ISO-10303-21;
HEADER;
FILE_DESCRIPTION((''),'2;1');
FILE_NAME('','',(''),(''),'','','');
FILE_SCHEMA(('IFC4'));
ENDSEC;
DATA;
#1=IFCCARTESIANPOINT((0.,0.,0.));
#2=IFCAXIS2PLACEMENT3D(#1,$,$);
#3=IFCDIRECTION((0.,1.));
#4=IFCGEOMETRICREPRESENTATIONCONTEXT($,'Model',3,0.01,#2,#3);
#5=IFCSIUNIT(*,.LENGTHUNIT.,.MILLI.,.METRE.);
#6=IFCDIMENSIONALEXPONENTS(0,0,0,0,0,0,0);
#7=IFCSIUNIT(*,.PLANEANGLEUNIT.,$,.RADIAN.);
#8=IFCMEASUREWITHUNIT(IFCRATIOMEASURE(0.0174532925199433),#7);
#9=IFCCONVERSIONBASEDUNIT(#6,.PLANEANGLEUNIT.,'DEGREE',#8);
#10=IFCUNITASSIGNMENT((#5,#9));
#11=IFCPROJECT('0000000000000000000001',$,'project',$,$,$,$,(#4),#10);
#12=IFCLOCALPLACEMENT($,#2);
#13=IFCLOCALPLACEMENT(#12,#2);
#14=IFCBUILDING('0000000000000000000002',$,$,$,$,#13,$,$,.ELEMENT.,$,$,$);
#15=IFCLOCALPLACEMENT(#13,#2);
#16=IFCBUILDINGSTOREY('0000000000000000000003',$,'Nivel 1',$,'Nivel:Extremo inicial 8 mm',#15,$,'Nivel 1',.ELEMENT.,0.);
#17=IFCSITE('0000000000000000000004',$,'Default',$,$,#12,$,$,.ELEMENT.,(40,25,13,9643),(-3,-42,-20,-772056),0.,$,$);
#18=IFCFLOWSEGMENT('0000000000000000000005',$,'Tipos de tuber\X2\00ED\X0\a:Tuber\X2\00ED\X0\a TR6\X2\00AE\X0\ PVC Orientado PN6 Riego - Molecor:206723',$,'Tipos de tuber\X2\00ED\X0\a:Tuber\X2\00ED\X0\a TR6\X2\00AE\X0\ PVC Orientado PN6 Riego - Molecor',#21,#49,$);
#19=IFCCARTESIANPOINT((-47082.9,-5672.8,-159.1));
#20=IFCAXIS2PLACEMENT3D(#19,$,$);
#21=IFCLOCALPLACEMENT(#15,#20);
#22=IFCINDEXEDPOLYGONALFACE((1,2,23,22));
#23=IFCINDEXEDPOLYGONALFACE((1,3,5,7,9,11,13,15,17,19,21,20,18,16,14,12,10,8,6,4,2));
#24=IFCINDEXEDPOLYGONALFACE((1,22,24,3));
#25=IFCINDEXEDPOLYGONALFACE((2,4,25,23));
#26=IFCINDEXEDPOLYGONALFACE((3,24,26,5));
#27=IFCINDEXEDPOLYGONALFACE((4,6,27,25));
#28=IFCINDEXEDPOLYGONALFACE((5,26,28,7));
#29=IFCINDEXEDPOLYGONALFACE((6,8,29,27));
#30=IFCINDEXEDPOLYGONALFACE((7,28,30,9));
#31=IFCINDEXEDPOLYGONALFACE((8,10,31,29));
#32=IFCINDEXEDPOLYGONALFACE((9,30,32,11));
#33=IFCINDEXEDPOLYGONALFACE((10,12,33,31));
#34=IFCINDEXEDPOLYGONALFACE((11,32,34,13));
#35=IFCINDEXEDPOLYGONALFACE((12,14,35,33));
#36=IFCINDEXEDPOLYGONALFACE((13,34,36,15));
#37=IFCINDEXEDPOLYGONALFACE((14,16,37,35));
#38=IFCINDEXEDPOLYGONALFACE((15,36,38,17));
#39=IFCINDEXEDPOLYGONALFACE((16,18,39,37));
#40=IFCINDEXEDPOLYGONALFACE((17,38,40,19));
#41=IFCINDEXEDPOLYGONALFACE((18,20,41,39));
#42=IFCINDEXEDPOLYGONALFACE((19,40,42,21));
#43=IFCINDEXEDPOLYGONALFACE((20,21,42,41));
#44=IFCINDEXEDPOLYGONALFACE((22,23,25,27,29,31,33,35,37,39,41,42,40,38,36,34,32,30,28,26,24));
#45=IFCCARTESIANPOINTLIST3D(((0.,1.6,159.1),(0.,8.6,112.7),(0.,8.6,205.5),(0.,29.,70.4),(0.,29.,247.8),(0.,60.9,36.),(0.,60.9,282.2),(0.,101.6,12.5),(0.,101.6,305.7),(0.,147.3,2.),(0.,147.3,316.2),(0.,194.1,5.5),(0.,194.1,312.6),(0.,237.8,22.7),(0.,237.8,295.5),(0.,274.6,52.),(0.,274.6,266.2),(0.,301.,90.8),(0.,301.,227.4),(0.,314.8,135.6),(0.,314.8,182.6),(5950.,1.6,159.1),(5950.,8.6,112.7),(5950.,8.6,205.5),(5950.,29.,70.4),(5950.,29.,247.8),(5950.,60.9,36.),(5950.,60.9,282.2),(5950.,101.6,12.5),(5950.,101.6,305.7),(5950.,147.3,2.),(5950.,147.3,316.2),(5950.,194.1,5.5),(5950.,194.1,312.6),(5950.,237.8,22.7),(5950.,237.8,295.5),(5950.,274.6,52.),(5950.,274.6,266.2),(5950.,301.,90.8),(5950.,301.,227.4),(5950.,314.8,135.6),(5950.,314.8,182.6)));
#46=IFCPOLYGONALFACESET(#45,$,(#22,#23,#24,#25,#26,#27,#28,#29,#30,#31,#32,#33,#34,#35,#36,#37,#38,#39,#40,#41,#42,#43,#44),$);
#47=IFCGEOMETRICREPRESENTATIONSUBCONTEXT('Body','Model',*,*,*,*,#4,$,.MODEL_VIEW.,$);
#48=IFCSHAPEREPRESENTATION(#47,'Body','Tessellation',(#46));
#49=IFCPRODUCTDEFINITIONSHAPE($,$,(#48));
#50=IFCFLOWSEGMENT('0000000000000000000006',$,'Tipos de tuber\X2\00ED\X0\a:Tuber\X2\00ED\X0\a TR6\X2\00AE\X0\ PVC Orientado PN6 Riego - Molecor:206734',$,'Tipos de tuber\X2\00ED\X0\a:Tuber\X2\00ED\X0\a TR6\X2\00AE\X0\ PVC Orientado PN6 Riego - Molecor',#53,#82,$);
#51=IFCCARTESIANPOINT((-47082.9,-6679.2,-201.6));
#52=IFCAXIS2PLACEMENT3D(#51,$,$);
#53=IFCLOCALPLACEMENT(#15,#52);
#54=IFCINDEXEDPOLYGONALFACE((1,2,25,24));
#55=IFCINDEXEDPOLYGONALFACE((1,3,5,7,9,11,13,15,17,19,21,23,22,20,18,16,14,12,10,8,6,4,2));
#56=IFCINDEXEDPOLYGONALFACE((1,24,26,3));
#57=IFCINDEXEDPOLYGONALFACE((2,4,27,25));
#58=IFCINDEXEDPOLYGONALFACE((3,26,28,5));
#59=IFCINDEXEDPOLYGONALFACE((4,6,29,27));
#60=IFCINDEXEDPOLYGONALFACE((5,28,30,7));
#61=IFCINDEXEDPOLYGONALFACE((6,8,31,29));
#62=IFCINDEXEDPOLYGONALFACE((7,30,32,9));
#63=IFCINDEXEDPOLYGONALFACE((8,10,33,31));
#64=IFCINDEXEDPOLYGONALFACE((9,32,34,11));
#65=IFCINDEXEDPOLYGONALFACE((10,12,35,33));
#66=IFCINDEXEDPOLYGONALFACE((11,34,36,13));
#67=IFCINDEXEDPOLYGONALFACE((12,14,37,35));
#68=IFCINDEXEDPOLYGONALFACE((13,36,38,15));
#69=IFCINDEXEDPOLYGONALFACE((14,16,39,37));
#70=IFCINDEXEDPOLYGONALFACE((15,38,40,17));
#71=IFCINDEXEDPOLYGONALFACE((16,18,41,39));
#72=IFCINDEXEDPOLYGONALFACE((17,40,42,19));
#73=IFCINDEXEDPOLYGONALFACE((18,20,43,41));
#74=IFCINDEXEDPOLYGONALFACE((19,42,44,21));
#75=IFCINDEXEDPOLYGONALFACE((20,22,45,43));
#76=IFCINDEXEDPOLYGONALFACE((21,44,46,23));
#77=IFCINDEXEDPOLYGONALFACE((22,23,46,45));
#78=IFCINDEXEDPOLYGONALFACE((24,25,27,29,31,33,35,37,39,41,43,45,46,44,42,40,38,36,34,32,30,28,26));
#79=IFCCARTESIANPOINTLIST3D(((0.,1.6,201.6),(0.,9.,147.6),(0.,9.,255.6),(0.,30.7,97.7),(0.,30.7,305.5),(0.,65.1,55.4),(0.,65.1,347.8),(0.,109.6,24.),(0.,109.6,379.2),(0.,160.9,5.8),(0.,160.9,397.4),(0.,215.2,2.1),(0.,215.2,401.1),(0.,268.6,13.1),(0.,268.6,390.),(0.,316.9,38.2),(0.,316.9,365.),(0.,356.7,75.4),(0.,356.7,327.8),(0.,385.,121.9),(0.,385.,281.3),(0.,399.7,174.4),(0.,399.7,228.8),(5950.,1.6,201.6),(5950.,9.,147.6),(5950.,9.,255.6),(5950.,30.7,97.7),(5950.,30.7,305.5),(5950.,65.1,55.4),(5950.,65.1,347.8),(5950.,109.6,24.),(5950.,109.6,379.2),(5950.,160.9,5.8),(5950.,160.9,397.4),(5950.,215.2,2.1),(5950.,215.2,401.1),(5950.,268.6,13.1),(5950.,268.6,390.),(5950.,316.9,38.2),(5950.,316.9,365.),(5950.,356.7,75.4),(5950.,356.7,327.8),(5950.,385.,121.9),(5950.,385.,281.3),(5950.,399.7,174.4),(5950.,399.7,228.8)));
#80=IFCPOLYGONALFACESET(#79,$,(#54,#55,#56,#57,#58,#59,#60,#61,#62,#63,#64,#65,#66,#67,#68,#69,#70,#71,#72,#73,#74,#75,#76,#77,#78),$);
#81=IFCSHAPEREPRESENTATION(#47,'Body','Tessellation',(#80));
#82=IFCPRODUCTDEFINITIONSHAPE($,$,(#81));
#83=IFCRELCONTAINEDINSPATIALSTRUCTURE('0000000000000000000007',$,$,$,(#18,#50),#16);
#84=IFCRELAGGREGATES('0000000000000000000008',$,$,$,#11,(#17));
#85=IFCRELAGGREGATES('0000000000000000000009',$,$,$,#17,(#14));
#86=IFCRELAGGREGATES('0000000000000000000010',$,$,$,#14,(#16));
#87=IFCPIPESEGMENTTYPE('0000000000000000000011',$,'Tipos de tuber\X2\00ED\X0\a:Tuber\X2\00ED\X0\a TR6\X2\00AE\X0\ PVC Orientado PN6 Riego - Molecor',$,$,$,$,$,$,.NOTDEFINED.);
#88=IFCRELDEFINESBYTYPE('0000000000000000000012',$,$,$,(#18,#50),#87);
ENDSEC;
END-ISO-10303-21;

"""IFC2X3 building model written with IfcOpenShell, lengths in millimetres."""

from ifc_helpers import new_model, entity, si_unit, converted_unit, direction, frame, frame_2d, origin, place, context, subcontext, project, spatial, circle, extrude, type_object, element, save


model = new_model("IFC2X3")

# Units and contexts
model_context = context("Model", 3, precision=0.01, world=origin(), true_north=direction((0.0, 1.0)))
body_context = subcontext(model_context, "Body", "Model", "MODEL_VIEW")
ifc_project = project(units=[si_unit("LENGTHUNIT", "METRE", prefix="MILLI"), converted_unit("PLANEANGLEUNIT", "DEGREE", entity("IfcRatioMeasure", 0.0174532925199433), si_unit("PLANEANGLEUNIT", "RADIAN"), dimensions=[0, 0, 0, 0, 0, 0, 0])], contexts=[model_context])

# Site, building, storey
site_placement = place(None, origin())
site = spatial("IfcSite", under=ifc_project, at=site_placement, Name="Default", CompositionType="ELEMENT", RefLatitude=(40, 25, 13, 9643), RefLongitude=(-3, -42, -20, -772056), RefElevation=0.0)
building_placement = place(site_placement, origin())
building = spatial("IfcBuilding", under=site, at=building_placement, CompositionType="ELEMENT")
storey_placement = place(building_placement, origin())
storey = spatial("IfcBuildingStorey", under=building, at=storey_placement, Name="Nivel 1", ObjectType="Nivel:Extremo inicial 8 mm", LongName="Nivel 1", CompositionType="ELEMENT", Elevation=0.0)

# Flow segments
pipe_segment_type = type_object("IfcPipeSegmentType", Name="Tipos de tubería:Tubería TR6® PVC Orientado PN6 Riego - Molecor", PredefinedType="NOTDEFINED")
flow_segment_1_placement = place(storey_placement, frame((-47082.9, -5672.8, -159.1)))
element("IfcFlowSegment", 1, at=flow_segment_1_placement, inside=storey, type_object=pipe_segment_type, Name="Tipos de tubería:Tubería TR6® PVC Orientado PN6 Riego - Molecor:206723", ObjectType="Tipos de tubería:Tubería TR6® PVC Orientado PN6 Riego - Molecor", context=body_context, shape_type="SweptSolid", body=[
    extrude(circle(Radius=157.5, at=frame_2d((0.0, 0.0), x_axis=(1.0, 0.0))), frame((0.0, 159.1, 159.1), z_axis=(1.0, 0.0, 0.0), x_axis=(0.0, -1.0, 0.0)), (0.0, 0.0, 1.0), 5950.0),
])
flow_segment_2_placement = place(storey_placement, frame((-47082.9, -6679.2, -201.6)))
element("IfcFlowSegment", 2, at=flow_segment_2_placement, inside=storey, type_object=pipe_segment_type, Name="Tipos de tubería:Tubería TR6® PVC Orientado PN6 Riego - Molecor:206734", ObjectType="Tipos de tubería:Tubería TR6® PVC Orientado PN6 Riego - Molecor", context=body_context, shape_type="SweptSolid", body=[
    extrude(circle(Radius=200.0, at=frame_2d((0.0, 0.0), x_axis=(1.0, 0.0))), frame((0.0, 201.6, 201.6), z_axis=(1.0, 0.0, 0.0), x_axis=(0.0, -1.0, 0.0)), (0.0, 0.0, 1.0), 5950.0),
])

save(model, "model.ifc")
